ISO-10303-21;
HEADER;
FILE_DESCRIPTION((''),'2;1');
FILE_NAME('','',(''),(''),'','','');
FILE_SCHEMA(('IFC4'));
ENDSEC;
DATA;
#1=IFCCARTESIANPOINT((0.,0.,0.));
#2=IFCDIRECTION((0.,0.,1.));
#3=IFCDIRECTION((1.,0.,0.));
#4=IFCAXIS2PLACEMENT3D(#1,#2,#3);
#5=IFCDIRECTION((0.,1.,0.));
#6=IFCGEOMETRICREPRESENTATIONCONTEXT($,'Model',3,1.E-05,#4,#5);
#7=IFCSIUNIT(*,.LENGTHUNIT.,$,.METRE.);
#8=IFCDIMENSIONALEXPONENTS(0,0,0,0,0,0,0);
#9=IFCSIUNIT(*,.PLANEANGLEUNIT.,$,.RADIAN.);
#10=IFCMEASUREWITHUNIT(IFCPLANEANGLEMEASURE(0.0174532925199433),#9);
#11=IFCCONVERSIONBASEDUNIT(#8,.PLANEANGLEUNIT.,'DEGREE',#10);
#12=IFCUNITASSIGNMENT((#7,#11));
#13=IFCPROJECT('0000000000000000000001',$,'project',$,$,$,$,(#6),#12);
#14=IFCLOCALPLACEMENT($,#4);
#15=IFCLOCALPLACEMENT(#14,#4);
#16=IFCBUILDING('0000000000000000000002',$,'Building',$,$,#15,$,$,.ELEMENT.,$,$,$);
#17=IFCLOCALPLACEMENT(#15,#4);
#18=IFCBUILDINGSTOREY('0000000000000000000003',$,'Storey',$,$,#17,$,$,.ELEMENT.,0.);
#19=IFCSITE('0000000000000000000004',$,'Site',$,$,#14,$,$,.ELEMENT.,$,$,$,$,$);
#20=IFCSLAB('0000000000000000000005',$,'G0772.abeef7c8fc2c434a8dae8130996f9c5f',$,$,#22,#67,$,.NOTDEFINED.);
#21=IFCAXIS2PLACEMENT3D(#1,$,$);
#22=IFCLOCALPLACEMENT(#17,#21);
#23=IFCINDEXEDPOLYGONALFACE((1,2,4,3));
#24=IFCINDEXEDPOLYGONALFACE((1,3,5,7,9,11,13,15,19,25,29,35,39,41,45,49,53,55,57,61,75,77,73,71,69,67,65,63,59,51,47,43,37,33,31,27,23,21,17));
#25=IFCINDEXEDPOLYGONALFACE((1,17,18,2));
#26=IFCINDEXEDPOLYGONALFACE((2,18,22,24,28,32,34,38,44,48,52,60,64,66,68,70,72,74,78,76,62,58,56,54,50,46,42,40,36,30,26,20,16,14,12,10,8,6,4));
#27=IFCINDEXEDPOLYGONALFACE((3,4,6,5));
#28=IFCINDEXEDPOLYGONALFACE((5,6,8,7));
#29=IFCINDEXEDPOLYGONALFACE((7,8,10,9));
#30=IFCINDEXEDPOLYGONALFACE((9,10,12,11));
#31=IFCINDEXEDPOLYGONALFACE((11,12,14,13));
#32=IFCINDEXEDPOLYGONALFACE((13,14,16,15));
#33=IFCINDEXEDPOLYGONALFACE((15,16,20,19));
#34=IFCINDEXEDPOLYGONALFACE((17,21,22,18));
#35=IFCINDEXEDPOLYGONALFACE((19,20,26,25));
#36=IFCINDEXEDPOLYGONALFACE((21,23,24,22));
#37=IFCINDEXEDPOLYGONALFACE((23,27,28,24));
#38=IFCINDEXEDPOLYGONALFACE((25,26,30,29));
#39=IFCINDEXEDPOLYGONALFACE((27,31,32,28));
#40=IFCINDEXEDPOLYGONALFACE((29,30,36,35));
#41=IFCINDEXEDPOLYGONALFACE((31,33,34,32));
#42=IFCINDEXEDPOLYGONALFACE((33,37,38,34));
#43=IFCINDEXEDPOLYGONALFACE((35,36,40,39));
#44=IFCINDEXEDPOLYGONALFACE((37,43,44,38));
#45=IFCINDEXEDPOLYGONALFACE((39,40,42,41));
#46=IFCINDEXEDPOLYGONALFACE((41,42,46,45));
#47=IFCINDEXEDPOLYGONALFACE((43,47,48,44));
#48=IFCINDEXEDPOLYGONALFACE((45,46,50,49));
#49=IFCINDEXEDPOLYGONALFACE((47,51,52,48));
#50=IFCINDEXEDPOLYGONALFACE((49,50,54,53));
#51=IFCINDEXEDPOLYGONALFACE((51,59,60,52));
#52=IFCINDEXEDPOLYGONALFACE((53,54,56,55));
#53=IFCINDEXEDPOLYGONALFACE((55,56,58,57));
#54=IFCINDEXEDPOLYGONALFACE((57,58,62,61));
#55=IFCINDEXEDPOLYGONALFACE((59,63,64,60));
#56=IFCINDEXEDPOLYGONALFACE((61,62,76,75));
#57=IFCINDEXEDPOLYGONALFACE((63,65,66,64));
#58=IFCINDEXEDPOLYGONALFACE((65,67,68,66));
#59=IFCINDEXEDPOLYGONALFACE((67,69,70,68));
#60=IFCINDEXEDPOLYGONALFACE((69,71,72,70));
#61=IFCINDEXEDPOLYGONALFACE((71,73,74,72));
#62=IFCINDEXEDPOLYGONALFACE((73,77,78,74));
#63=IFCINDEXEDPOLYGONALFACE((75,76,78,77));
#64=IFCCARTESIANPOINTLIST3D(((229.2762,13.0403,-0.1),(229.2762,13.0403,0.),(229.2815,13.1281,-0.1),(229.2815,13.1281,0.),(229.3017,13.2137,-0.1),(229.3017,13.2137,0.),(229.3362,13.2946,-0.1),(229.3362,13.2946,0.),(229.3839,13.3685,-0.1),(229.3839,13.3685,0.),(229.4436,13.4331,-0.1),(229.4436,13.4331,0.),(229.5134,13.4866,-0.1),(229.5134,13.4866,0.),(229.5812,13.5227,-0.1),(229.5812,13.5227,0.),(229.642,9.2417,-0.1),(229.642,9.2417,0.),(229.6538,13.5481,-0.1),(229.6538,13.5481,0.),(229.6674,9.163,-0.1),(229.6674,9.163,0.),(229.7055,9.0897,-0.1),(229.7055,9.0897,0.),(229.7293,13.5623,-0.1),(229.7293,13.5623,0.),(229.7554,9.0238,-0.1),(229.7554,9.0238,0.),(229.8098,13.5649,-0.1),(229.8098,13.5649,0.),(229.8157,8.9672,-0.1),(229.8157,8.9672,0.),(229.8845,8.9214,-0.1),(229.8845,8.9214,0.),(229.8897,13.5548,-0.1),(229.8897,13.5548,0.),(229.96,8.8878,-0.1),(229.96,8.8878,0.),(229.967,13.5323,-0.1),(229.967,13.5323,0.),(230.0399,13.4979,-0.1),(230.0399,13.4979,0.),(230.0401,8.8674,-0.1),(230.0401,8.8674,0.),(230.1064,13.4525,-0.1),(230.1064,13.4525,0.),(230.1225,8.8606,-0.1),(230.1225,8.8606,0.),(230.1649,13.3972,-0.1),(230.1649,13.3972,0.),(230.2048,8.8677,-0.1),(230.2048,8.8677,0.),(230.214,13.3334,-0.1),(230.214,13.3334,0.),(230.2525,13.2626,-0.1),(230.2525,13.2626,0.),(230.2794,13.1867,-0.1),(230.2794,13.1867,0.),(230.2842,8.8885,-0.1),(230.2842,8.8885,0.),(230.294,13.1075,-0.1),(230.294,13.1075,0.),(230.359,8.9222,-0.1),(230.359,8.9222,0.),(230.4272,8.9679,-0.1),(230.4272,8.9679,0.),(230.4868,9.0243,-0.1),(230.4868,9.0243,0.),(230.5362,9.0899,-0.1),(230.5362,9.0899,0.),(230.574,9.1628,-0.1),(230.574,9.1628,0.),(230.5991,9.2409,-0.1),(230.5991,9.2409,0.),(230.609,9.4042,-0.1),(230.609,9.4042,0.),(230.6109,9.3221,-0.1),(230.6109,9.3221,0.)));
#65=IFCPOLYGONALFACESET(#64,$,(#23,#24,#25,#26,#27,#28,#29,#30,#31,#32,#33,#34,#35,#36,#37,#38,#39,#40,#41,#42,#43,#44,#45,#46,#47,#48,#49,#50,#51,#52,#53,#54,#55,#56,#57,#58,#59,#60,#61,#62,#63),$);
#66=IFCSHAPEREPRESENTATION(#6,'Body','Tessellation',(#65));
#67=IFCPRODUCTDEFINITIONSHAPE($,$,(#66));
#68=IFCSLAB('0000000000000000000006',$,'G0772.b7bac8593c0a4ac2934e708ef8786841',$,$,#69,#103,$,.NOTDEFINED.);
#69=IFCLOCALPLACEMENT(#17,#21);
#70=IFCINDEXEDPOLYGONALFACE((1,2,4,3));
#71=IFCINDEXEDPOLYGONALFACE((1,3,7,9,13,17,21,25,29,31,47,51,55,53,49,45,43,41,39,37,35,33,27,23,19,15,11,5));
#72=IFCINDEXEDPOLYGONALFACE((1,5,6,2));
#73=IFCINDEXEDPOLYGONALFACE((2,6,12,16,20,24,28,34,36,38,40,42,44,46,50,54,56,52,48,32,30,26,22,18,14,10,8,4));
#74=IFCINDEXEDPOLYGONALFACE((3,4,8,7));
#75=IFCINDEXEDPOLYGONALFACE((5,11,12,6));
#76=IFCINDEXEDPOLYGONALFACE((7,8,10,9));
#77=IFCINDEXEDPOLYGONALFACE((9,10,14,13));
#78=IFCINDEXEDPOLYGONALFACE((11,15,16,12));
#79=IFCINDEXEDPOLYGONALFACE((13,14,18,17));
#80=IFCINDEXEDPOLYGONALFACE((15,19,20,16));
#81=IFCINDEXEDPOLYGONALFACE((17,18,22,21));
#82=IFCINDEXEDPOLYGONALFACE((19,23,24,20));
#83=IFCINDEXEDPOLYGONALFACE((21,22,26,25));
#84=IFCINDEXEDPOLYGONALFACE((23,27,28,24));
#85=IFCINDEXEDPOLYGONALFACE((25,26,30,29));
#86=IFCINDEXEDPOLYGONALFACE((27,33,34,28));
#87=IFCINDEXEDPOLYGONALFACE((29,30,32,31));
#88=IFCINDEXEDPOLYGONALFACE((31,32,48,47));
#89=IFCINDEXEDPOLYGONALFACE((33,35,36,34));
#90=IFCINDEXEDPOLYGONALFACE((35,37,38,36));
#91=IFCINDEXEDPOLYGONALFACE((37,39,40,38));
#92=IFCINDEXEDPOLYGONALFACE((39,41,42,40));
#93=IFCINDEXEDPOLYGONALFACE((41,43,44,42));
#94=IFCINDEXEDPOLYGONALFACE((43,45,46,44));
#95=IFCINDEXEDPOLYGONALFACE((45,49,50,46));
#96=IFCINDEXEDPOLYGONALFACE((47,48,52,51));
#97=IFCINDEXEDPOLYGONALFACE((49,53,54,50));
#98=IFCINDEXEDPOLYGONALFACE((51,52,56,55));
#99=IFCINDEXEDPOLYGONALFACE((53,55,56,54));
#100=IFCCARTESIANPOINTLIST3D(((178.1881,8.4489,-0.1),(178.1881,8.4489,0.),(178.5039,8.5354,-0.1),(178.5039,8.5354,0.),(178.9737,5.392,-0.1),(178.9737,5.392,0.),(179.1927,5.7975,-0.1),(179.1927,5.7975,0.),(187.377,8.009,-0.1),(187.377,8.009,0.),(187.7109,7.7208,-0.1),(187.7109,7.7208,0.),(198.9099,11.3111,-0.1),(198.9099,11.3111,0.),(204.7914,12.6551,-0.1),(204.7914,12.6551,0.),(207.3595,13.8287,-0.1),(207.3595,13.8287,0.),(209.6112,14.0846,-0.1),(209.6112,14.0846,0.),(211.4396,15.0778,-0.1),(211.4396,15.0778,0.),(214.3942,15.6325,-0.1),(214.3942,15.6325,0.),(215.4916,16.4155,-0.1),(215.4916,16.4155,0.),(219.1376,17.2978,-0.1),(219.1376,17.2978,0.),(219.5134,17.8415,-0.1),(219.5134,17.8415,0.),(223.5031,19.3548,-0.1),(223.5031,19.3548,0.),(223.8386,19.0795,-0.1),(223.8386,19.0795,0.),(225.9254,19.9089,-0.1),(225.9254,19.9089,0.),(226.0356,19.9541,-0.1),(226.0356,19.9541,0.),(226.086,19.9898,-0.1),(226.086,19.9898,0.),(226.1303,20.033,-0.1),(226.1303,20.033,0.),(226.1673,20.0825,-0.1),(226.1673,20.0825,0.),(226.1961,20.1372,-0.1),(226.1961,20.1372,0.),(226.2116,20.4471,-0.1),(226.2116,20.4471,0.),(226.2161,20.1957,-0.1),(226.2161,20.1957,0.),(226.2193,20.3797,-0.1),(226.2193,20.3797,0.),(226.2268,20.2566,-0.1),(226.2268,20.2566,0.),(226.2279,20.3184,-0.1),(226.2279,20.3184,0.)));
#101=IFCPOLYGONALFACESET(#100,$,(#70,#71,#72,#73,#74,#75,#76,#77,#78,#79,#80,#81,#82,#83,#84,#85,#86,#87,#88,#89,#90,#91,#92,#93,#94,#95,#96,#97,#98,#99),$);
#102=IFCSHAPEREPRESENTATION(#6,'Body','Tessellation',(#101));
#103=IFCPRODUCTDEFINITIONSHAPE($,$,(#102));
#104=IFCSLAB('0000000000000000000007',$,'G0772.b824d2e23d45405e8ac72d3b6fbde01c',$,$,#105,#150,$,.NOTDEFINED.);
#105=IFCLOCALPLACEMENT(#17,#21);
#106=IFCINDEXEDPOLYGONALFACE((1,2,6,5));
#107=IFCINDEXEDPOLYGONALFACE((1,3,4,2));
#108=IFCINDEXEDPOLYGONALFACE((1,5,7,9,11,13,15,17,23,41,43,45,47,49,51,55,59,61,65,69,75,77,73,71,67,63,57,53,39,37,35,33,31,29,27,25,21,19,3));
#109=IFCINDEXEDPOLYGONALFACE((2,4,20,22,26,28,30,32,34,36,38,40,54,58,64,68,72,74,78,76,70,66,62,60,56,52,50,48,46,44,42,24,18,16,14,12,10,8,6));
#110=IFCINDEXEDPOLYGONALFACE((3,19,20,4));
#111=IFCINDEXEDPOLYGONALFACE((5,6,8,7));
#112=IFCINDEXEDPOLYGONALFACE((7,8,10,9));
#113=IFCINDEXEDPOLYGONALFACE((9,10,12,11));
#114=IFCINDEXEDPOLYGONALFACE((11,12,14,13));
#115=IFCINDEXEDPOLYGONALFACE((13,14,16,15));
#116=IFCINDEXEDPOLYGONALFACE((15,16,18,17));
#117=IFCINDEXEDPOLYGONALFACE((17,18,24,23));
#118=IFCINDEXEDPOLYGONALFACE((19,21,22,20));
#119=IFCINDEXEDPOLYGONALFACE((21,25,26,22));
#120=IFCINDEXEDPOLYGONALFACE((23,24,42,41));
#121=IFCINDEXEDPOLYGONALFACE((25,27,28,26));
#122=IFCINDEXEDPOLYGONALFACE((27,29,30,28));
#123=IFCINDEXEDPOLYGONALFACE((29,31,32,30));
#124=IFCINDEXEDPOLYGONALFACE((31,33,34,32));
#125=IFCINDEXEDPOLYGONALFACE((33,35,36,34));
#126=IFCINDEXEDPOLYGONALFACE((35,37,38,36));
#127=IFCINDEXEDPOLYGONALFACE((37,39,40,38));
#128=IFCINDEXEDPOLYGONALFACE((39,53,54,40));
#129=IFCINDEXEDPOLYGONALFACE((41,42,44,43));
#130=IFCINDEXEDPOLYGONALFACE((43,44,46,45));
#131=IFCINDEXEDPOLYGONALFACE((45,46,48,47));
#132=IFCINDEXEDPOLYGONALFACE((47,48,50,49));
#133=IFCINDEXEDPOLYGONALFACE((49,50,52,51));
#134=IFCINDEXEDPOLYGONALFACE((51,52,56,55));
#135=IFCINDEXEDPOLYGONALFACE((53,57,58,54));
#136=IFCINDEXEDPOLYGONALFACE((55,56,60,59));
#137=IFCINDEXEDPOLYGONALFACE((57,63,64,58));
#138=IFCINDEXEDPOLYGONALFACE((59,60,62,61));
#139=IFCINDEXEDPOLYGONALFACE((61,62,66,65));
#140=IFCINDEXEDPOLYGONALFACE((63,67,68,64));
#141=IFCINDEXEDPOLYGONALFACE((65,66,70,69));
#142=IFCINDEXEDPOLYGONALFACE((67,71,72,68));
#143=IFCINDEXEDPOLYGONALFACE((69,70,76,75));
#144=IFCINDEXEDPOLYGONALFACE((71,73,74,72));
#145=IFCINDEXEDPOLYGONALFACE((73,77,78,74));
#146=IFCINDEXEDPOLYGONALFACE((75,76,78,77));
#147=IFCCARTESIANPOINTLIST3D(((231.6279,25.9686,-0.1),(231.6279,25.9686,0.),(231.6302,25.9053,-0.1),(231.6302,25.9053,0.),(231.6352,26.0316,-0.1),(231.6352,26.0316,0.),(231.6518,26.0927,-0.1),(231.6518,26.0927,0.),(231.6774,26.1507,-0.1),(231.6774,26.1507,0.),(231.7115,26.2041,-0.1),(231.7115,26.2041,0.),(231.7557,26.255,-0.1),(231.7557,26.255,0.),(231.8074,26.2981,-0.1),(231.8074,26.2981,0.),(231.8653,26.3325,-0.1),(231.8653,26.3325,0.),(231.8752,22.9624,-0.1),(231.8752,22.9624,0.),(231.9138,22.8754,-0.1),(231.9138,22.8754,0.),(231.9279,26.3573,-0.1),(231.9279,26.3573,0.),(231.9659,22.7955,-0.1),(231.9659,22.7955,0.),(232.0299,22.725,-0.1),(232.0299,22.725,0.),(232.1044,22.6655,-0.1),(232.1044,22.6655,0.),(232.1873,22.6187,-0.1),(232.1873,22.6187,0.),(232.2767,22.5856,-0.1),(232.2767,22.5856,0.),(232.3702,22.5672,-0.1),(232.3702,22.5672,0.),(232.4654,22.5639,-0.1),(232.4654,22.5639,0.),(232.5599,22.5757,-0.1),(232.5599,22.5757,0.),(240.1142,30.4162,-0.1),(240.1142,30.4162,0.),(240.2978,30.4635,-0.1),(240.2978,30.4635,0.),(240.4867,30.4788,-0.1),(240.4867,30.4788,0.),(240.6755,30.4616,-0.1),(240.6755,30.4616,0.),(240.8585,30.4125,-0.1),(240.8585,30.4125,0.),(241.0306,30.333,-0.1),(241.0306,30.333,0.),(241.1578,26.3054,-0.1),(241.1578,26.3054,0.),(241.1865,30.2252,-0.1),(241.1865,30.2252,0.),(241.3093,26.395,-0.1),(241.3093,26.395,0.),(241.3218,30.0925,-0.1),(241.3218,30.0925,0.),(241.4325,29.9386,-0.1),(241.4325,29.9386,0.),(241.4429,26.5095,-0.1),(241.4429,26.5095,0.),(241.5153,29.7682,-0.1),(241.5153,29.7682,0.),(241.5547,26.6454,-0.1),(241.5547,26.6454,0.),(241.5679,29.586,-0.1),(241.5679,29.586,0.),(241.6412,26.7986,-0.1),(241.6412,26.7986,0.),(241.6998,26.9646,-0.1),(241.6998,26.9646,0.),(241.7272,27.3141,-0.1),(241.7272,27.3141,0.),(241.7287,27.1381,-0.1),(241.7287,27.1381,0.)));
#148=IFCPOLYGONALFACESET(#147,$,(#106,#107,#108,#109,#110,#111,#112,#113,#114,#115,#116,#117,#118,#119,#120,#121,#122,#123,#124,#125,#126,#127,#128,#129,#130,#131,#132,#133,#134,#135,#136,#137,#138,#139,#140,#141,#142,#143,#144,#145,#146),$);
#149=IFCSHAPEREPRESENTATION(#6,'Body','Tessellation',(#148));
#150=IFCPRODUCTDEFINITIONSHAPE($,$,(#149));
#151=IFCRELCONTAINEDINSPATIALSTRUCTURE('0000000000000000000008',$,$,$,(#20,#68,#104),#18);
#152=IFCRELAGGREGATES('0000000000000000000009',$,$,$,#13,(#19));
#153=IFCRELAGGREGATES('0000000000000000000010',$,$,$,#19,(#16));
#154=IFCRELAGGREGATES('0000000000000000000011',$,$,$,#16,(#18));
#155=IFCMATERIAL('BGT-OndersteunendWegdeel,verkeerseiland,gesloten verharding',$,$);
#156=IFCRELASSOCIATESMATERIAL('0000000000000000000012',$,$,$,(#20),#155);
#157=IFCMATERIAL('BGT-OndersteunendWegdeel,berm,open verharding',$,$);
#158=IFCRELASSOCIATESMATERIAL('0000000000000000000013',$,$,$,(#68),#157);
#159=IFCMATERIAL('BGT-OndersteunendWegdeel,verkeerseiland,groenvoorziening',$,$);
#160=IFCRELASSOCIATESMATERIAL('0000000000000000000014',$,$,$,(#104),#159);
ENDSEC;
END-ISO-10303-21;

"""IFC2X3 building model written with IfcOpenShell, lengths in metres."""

from ifc_helpers import new_model, entity, si_unit, converted_unit, direction, frame, origin_with_axes, place, context, project, spatial, polyline, outline, extrude, material, element, save


model = new_model("IFC2X3")

# Units and contexts
model_context = context("Model", 3, precision=1e-05, world=origin_with_axes(), true_north=direction((0.0, 1.0, 0.0)))
ifc_project = project(units=[si_unit("LENGTHUNIT", "METRE"), converted_unit("PLANEANGLEUNIT", "DEGREE", entity("IfcPlaneAngleMeasure", 0.0174532925199433), si_unit("PLANEANGLEUNIT", "RADIAN"), dimensions=[0, 0, 0, 0, 0, 0, 0])], contexts=[model_context])

# Site, building, storey
site_placement = place(None, origin_with_axes())
site = spatial("IfcSite", under=ifc_project, at=site_placement, Name="Site", CompositionType="ELEMENT")
building_placement = place(site_placement, origin_with_axes())
building = spatial("IfcBuilding", under=site, at=building_placement, Name="Building", CompositionType="ELEMENT")
storey_placement = place(building_placement, origin_with_axes())
storey = spatial("IfcBuildingStorey", under=building, at=storey_placement, Name="Storey", CompositionType="ELEMENT", Elevation=0.0)

# Slabs
ifc_material_1 = material(Name="BGT-OndersteunendWegdeel,berm,open verharding")
ifc_material_2 = material(Name="BGT-OndersteunendWegdeel,verkeerseiland,gesloten verharding")
ifc_material_3 = material(Name="BGT-OndersteunendWegdeel,verkeerseiland,groenvoorziening")
slab_1_placement = place(storey_placement, frame((0.0, 0.0, -0.1), z_axis=(0.0, 0.0, 1.0), x_axis=(1.0, 0.0, 0.0)))
element("IfcSlab", 1, at=slab_1_placement, inside=storey, material=ifc_material_2, Name="G0772.abeef7c8fc2c434a8dae8130996f9c5f", PredefinedType="NOTDEFINED", context=model_context, shape_type="SweptSolid", body=[
    extrude(outline(polyline([(229.8098, 13.5649), (229.8897, 13.5548), (229.967, 13.5323), (230.0399, 13.4979), (230.1064, 13.4525), (230.1649, 13.3972), (230.214, 13.3334), (230.2525, 13.2626), (230.2794, 13.1867), (230.294, 13.1075), (230.609, 9.4042), (230.6109, 9.3221), (230.5991, 9.2409), (230.574, 9.1628), (230.5362, 9.0899), (230.4868, 9.0243), (230.4272, 8.9679), (230.359, 8.9222), (230.2842, 8.8885), (230.2048, 8.8677), (230.1225, 8.8606), (230.0401, 8.8674), (229.96, 8.8878), (229.8845, 8.9214), (229.8157, 8.9672), (229.7554, 9.0238), (229.7055, 9.0897), (229.6674, 9.163), (229.642, 9.2417), (229.2762, 13.0403), (229.2815, 13.1281), (229.3017, 13.2137), (229.3362, 13.2946), (229.3839, 13.3685), (229.4436, 13.4331), (229.5134, 13.4866), (229.5812, 13.5227), (229.6538, 13.5481), (229.7293, 13.5623), (229.8098, 13.5649)])), origin_with_axes(), (0.0, 0.0, 1.0), 0.1),
])
slab_2_placement = place(storey_placement, frame((0.0, 0.0, -0.1), z_axis=(0.0, 0.0, 1.0), x_axis=(1.0, 0.0, 0.0)))
element("IfcSlab", 2, at=slab_2_placement, inside=storey, material=ifc_material_1, Name="G0772.b7bac8593c0a4ac2934e708ef8786841", PredefinedType="NOTDEFINED", context=model_context, shape_type="SweptSolid", body=[
    extrude(outline(polyline([(198.9099, 11.3111), (207.3595, 13.8287), (211.4396, 15.0778), (215.4916, 16.4155), (219.5134, 17.8415), (223.5031, 19.3548), (226.2116, 20.4471), (226.2193, 20.3797), (226.2279, 20.3184), (226.2268, 20.2566), (226.2161, 20.1957), (226.1961, 20.1372), (226.1673, 20.0825), (226.1303, 20.033), (226.086, 19.9898), (226.0356, 19.9541), (225.9254, 19.9089), (223.8386, 19.0795), (219.1376, 17.2978), (214.3942, 15.6325), (209.6112, 14.0846), (204.7914, 12.6551), (187.7109, 7.7208), (178.9737, 5.392), (178.1881, 8.4489), (178.5039, 8.5354), (179.1927, 5.7975), (187.377, 8.009), (198.9099, 11.3111)])), origin_with_axes(), (0.0, 0.0, 1.0), 0.1),
])
slab_3_placement = place(storey_placement, frame((0.0, 0.0, -0.1), z_axis=(0.0, 0.0, 1.0), x_axis=(1.0, 0.0, 0.0)))
element("IfcSlab", 3, at=slab_3_placement, inside=storey, material=ifc_material_3, Name="G0772.b824d2e23d45405e8ac72d3b6fbde01c", PredefinedType="NOTDEFINED", context=model_context, shape_type="SweptSolid", body=[
    extrude(outline(polyline([(231.7557, 26.255), (231.8074, 26.2981), (231.8653, 26.3325), (231.9279, 26.3573), (240.1142, 30.4162), (240.2978, 30.4635), (240.4867, 30.4788), (240.6755, 30.4616), (240.8585, 30.4125), (241.0306, 30.333), (241.1865, 30.2252), (241.3218, 30.0925), (241.4325, 29.9386), (241.5153, 29.7682), (241.5679, 29.586), (241.7272, 27.3141), (241.7287, 27.1381), (241.6998, 26.9646), (241.6412, 26.7986), (241.5547, 26.6454), (241.4429, 26.5095), (241.3093, 26.395), (241.1578, 26.3054), (232.5599, 22.5757), (232.4654, 22.5639), (232.3702, 22.5672), (232.2767, 22.5856), (232.1873, 22.6187), (232.1044, 22.6655), (232.0299, 22.725), (231.9659, 22.7955), (231.9138, 22.8754), (231.8752, 22.9624), (231.6302, 25.9053), (231.6279, 25.9686), (231.6352, 26.0316), (231.6518, 26.0927), (231.6774, 26.1507), (231.7115, 26.2041), (231.7557, 26.255)])), origin_with_axes(), (0.0, 0.0, 1.0), 0.1),
])

save(model, "model.ifc")
